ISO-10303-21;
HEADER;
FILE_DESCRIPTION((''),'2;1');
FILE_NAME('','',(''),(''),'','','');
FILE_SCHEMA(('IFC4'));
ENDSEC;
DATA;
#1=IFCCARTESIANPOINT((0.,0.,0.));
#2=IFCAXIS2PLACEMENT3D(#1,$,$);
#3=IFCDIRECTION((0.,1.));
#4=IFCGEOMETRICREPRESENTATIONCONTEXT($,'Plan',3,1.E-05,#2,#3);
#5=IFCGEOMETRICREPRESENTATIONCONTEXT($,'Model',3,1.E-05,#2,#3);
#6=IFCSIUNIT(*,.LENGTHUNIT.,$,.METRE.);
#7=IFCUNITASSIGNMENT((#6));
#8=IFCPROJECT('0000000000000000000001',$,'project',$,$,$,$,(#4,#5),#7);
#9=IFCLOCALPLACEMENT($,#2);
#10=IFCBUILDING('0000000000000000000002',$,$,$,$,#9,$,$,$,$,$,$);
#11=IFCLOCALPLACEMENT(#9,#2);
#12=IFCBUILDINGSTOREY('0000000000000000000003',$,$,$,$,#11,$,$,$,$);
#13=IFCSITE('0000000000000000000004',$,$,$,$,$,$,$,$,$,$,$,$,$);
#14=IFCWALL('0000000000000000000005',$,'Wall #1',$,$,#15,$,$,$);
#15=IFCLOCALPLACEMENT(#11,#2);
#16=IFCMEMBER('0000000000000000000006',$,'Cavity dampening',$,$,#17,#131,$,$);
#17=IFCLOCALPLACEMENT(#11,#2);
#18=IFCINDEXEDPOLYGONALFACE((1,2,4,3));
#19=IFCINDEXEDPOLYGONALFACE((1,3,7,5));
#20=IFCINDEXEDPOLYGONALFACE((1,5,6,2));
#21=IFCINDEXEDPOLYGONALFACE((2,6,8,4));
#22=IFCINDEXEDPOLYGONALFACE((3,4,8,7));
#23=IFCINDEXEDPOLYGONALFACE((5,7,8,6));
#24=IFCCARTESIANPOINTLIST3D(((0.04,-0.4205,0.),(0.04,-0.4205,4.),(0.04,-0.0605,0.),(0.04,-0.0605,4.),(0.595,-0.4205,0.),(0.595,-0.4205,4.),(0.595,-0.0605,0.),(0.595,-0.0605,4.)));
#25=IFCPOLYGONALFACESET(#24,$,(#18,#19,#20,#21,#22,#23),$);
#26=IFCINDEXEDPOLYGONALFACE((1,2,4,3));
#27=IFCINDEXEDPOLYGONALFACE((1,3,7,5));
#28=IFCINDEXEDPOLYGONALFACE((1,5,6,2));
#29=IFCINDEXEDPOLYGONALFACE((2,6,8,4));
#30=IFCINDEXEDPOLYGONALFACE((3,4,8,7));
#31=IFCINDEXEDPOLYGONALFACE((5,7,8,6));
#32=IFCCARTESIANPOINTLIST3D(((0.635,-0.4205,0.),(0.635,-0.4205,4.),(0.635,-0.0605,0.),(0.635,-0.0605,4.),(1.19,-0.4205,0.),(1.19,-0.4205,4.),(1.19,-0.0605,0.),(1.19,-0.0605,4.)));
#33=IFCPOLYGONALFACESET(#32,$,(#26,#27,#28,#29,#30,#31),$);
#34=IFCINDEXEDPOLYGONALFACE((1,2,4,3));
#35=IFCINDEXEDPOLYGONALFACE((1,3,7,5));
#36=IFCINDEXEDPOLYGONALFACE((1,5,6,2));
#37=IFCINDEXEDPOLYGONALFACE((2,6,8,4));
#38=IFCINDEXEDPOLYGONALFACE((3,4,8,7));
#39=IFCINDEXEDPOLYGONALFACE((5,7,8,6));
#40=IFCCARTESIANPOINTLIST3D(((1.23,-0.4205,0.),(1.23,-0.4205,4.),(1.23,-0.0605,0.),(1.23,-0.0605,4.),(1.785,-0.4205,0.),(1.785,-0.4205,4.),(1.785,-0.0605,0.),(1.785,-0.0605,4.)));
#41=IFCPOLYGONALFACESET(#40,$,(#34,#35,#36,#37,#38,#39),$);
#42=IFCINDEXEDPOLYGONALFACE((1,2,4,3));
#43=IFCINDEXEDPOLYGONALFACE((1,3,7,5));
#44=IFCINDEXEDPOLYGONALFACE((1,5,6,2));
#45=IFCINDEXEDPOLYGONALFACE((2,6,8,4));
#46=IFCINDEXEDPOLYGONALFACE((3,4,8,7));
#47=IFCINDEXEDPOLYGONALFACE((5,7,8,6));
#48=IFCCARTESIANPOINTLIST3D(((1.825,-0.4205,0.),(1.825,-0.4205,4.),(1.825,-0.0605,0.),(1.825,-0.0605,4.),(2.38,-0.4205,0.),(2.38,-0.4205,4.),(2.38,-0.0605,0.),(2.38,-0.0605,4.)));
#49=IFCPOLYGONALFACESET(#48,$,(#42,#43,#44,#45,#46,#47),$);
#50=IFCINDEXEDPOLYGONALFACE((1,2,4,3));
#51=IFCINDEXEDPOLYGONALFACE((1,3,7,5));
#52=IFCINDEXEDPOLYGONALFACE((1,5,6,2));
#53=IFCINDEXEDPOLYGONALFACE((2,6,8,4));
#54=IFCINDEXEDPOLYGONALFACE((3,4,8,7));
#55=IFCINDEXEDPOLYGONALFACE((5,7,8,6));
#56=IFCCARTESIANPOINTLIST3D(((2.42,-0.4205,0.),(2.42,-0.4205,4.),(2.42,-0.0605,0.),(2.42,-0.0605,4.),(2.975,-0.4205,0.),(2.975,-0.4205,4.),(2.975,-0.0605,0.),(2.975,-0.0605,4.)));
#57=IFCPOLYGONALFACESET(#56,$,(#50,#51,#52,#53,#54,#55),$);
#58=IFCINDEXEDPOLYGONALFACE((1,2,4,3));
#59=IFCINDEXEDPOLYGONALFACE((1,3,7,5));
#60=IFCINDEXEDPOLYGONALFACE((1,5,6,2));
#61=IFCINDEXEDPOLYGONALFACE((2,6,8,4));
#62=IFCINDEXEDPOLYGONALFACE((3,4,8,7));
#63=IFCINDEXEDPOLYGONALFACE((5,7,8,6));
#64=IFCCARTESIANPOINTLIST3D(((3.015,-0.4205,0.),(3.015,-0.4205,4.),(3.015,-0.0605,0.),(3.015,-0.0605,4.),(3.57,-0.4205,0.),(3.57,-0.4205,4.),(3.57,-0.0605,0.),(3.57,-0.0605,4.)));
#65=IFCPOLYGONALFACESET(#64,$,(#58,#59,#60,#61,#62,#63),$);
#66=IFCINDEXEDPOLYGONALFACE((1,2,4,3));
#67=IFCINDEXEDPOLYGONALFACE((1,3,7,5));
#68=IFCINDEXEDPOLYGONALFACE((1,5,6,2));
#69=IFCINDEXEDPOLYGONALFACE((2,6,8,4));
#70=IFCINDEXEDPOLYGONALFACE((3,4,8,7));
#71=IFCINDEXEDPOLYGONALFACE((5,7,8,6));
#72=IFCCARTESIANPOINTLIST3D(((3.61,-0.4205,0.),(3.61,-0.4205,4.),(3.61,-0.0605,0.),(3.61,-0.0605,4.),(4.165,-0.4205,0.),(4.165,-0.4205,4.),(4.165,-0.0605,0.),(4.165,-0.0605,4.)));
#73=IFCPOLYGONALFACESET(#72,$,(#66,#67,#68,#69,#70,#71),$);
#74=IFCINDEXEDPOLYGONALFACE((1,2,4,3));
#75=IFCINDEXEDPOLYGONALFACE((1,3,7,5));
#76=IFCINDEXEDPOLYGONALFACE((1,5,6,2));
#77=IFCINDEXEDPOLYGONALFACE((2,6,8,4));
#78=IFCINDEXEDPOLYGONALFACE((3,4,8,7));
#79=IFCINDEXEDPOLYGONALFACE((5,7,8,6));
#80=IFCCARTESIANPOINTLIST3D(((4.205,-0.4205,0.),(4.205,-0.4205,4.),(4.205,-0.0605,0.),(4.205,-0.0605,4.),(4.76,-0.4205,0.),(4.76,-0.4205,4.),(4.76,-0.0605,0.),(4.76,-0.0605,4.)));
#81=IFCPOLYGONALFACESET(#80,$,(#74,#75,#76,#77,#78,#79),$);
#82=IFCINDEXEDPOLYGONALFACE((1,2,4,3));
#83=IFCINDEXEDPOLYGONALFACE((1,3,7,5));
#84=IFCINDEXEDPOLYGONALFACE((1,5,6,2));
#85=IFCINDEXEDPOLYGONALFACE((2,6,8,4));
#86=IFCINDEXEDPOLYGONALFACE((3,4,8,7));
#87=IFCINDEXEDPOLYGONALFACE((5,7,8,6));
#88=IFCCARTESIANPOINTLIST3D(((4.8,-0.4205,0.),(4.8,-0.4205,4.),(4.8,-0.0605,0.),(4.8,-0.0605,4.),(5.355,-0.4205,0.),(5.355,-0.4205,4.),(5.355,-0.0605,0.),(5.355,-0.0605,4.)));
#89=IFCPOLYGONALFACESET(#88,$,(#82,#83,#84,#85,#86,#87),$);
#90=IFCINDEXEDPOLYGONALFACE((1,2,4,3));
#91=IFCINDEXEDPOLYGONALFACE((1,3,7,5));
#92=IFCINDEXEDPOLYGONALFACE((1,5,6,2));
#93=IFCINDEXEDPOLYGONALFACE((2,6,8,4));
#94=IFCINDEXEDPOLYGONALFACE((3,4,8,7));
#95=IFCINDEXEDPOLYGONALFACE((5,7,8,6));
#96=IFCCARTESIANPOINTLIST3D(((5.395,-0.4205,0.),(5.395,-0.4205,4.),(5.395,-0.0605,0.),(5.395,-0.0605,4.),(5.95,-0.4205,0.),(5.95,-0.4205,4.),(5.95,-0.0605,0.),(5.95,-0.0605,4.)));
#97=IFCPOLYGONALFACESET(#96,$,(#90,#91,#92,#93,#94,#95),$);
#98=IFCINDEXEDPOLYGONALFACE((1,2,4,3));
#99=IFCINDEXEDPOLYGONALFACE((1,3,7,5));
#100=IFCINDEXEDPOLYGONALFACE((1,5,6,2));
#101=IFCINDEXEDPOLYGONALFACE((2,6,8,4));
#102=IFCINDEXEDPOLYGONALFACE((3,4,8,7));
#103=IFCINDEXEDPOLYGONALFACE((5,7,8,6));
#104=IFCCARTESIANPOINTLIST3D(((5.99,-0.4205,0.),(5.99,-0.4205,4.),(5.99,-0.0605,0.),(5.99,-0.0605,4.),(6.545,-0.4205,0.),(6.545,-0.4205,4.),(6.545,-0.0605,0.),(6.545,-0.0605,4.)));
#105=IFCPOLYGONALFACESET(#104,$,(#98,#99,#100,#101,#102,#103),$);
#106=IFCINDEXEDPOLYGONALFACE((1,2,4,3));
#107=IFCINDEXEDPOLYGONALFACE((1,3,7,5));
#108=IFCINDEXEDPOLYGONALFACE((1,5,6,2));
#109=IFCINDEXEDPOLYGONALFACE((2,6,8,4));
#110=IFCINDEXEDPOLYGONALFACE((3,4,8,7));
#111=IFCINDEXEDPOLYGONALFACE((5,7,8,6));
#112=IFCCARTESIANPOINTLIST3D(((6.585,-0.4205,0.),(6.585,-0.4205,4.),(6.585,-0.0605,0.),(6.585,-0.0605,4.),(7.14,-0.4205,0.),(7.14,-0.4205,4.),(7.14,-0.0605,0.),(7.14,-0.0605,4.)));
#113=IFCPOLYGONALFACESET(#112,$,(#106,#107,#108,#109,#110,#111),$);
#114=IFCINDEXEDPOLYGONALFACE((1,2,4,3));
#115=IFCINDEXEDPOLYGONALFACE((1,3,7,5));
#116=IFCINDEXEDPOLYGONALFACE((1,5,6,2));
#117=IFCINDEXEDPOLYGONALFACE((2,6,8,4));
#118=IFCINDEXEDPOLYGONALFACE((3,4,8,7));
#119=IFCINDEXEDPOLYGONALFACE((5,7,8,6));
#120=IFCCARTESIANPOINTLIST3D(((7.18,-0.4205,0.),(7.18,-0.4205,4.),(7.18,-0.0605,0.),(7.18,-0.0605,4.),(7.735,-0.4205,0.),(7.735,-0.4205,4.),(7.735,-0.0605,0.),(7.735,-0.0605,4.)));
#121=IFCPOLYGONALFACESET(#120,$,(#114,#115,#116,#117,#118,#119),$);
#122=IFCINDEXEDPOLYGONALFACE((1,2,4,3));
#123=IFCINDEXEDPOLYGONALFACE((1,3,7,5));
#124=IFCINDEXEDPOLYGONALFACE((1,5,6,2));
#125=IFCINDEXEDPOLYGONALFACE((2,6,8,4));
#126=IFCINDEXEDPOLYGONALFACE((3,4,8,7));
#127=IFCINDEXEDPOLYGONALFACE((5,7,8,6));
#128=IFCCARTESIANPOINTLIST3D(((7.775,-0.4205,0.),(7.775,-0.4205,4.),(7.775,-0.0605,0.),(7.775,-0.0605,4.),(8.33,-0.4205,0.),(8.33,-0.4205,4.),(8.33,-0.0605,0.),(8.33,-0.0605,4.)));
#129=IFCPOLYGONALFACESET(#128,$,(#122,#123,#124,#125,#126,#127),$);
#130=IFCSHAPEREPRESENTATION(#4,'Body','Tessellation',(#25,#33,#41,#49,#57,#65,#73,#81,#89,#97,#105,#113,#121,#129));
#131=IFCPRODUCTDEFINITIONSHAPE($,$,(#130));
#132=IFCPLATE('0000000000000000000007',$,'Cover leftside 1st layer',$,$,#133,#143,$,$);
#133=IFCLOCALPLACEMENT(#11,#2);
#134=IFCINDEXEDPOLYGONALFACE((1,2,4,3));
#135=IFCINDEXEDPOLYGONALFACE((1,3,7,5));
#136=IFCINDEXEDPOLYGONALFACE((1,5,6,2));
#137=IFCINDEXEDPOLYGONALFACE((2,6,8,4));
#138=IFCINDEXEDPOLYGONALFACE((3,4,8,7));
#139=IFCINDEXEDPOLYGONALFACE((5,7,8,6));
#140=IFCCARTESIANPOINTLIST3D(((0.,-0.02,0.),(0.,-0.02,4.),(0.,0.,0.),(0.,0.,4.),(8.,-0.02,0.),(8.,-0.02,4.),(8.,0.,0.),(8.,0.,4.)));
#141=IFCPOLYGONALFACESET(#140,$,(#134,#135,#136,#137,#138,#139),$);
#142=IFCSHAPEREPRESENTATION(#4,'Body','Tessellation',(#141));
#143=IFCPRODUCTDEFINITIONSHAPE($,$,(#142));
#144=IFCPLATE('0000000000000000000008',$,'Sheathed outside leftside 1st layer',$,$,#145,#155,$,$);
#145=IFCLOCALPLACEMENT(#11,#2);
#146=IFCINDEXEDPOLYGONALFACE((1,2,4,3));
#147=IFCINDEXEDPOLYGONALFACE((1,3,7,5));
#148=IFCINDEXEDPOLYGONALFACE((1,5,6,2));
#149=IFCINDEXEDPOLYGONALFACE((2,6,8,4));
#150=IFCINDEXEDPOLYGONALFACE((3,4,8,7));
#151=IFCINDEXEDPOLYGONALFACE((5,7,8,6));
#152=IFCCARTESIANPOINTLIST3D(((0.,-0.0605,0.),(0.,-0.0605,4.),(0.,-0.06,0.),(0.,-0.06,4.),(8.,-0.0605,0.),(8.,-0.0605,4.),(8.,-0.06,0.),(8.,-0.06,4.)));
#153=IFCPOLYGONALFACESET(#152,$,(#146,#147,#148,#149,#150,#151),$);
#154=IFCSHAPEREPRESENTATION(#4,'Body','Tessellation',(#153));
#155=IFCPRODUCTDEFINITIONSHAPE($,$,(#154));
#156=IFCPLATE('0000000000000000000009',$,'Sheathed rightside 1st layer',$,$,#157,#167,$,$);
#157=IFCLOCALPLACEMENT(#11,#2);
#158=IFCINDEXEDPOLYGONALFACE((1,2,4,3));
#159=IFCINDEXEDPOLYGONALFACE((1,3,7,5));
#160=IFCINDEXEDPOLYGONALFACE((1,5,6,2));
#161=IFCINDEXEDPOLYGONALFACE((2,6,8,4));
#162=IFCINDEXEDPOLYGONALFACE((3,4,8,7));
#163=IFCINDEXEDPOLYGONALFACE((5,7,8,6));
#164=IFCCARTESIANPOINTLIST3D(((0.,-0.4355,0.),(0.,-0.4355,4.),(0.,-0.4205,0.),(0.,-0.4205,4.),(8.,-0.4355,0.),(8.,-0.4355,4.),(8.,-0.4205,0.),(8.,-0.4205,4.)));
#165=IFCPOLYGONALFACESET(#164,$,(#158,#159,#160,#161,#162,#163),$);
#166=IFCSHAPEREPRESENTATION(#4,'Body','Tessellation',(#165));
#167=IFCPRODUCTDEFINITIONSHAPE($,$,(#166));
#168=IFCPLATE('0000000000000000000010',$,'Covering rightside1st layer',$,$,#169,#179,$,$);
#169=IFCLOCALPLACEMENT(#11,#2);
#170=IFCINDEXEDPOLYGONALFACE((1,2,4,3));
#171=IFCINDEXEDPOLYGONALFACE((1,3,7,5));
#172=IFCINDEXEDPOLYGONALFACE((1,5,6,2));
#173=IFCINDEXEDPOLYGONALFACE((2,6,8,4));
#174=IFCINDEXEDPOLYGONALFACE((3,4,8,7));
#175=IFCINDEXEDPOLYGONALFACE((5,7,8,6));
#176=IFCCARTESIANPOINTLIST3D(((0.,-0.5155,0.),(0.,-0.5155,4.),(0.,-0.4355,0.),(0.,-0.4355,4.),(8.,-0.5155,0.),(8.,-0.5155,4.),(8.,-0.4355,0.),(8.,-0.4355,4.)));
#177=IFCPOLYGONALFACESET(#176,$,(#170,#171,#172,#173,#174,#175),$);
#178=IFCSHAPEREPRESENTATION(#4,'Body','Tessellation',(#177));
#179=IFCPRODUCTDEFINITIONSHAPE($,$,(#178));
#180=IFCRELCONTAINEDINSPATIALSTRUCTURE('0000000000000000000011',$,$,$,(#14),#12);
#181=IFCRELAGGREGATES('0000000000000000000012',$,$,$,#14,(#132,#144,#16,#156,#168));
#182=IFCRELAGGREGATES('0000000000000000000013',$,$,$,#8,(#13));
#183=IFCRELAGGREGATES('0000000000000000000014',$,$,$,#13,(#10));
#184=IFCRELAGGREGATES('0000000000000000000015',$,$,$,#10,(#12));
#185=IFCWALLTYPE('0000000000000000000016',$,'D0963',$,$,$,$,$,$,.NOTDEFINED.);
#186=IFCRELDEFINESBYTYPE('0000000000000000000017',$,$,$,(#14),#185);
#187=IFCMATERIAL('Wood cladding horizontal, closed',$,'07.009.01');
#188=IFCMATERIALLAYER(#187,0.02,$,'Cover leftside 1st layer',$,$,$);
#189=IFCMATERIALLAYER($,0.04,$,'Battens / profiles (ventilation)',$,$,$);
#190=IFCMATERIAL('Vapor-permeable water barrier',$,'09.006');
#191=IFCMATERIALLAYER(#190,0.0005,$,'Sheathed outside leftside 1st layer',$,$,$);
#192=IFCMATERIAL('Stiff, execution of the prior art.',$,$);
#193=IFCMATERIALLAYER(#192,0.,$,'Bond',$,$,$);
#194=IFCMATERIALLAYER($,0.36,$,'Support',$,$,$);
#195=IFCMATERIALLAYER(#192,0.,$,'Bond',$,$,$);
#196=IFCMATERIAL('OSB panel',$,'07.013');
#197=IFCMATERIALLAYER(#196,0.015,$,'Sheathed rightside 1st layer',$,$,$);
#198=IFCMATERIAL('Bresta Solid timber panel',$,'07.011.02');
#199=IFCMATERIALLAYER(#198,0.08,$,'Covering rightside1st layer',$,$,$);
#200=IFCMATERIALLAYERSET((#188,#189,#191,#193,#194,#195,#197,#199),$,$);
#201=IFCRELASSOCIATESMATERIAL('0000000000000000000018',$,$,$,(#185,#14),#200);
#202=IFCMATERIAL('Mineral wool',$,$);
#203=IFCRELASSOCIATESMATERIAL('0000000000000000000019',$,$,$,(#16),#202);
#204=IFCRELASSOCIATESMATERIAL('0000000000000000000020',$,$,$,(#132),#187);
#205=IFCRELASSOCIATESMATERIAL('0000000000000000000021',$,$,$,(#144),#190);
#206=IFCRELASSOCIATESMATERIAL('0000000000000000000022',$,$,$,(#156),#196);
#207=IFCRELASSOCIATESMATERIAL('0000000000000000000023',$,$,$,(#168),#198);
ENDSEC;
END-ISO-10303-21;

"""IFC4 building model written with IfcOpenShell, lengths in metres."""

from ifc_helpers import new_model, si_unit, direction, frame, frame_2d, origin, origin_with_axes, place, context, project, spatial, rectangle, extrude, material, layer, layer_set, type_object, element, aggregate, save


model = new_model("IFC4")

# Units and contexts
plan_context = context("Plan", 3, precision=1e-05, world=origin(), true_north=direction((0.0, 1.0)))
model_context = context("Model", 3, precision=1e-05, world=origin(), true_north=direction((0.0, 1.0)))
ifc_project = project(units=[si_unit("LENGTHUNIT", "METRE")], contexts=[plan_context, model_context])

# Site, building, storey
site = spatial("IfcSite", under=ifc_project)
building_placement = place(None, origin())
building = spatial("IfcBuilding", under=site, at=building_placement)
storey_placement = place(building_placement, origin())
storey = spatial("IfcBuildingStorey", under=building, at=storey_placement)

# Wall, member, plates
ifc_material_1 = material(Name="Wood cladding horizontal, closed", Category="07.009.01")
ifc_layer_1 = layer(ifc_material_1, 0.02, Name="Cover leftside 1st layer")
ifc_layer_2 = layer(None, 0.04, Name="Battens / profiles (ventilation)")
ifc_material_2 = material(Name="Vapor-permeable water barrier", Category="09.006")
ifc_layer_3 = layer(ifc_material_2, 0.0005, Name="Sheathed outside leftside 1st layer")
ifc_material_3 = material(Name="Stiff, execution of the prior art.")
ifc_layer_4 = layer(ifc_material_3, 0.0, Name="Bond")
ifc_layer_5 = layer(None, 0.36, Name="Support")
ifc_layer_6 = layer(ifc_material_3, 0.0, Name="Bond")
ifc_material_4 = material(Name="OSB panel", Category="07.013")
ifc_layer_7 = layer(ifc_material_4, 0.015, Name="Sheathed rightside 1st layer")
ifc_material_5 = material(Name="Bresta Solid timber panel", Category="07.011.02")
ifc_layer_8 = layer(ifc_material_5, 0.08, Name="Covering rightside1st layer")
ifc_layer_set = layer_set([ifc_layer_1, ifc_layer_2, ifc_layer_3, ifc_layer_4, ifc_layer_5, ifc_layer_6, ifc_layer_7, ifc_layer_8])
wall_type = type_object("IfcWallType", Name="D0963", PredefinedType="NOTDEFINED", material=ifc_layer_set)
wall_placement = place(None, frame((0.0, 0.0, 0.0), z_axis=(0.0, -1.0, 0.0), x_axis=(1.0, 0.0, 0.0)))
wall = element("IfcWall", 1, at=wall_placement, inside=storey, type_object=wall_type, material=ifc_layer_set, Name="Wall #1")
ifc_material_6 = material(Name="Mineral wool")
member_1_placement = place(wall_placement, origin())
member_1 = element("IfcMember", 2, at=member_1_placement, material=ifc_material_6, Name="Cavity dampening", context=plan_context, shape_type="SweptSolid", body=[
    extrude(rectangle(XDim=0.555, YDim=0.36, at=frame_2d((0.2775, 0.18), x_axis=(1.0, 0.0))), frame((0.04, 4.0, 0.0605), z_axis=(0.0, -1.0, 0.0), x_axis=(1.0, 0.0, 0.0)), (0.0, 0.0, 1.0), 4.0),
    extrude(rectangle(XDim=0.555, YDim=0.36, at=frame_2d((0.2775, 0.18), x_axis=(1.0, 0.0))), frame((0.635, 4.0, 0.0605), z_axis=(0.0, -1.0, 0.0), x_axis=(1.0, 0.0, 0.0)), (0.0, 0.0, 1.0), 4.0),
    extrude(rectangle(XDim=0.555, YDim=0.36, at=frame_2d((0.2775, 0.18), x_axis=(1.0, 0.0))), frame((1.23, 4.0, 0.0605), z_axis=(0.0, -1.0, 0.0), x_axis=(1.0, 0.0, 0.0)), (0.0, 0.0, 1.0), 4.0),
    extrude(rectangle(XDim=0.555, YDim=0.36, at=frame_2d((0.2775, 0.18), x_axis=(1.0, 0.0))), frame((1.825, 4.0, 0.0605), z_axis=(0.0, -1.0, 0.0), x_axis=(1.0, 0.0, 0.0)), (0.0, 0.0, 1.0), 4.0),
    extrude(rectangle(XDim=0.555, YDim=0.36, at=frame_2d((0.2775, 0.18), x_axis=(1.0, 0.0))), frame((2.42, 4.0, 0.0605), z_axis=(0.0, -1.0, 0.0), x_axis=(1.0, 0.0, 0.0)), (0.0, 0.0, 1.0), 4.0),
    extrude(rectangle(XDim=0.555, YDim=0.36, at=frame_2d((0.2775, 0.18), x_axis=(1.0, 0.0))), frame((3.015, 4.0, 0.0605), z_axis=(0.0, -1.0, 0.0), x_axis=(1.0, 0.0, 0.0)), (0.0, 0.0, 1.0), 4.0),
    extrude(rectangle(XDim=0.555, YDim=0.36, at=frame_2d((0.2775, 0.18), x_axis=(1.0, 0.0))), frame((3.61, 4.0, 0.0605), z_axis=(0.0, -1.0, 0.0), x_axis=(1.0, 0.0, 0.0)), (0.0, 0.0, 1.0), 4.0),
    extrude(rectangle(XDim=0.555, YDim=0.36, at=frame_2d((0.2775, 0.18), x_axis=(1.0, 0.0))), frame((4.205, 4.0, 0.0605), z_axis=(0.0, -1.0, 0.0), x_axis=(1.0, 0.0, 0.0)), (0.0, 0.0, 1.0), 4.0),
    extrude(rectangle(XDim=0.555, YDim=0.36, at=frame_2d((0.2775, 0.18), x_axis=(1.0, 0.0))), frame((4.8, 4.0, 0.0605), z_axis=(0.0, -1.0, 0.0), x_axis=(1.0, 0.0, 0.0)), (0.0, 0.0, 1.0), 4.0),
    extrude(rectangle(XDim=0.555, YDim=0.36, at=frame_2d((0.2775, 0.18), x_axis=(1.0, 0.0))), frame((5.395, 4.0, 0.0605), z_axis=(0.0, -1.0, 0.0), x_axis=(1.0, 0.0, 0.0)), (0.0, 0.0, 1.0), 4.0),
    extrude(rectangle(XDim=0.555, YDim=0.36, at=frame_2d((0.2775, 0.18), x_axis=(1.0, 0.0))), frame((5.99, 4.0, 0.0605), z_axis=(0.0, -1.0, 0.0), x_axis=(1.0, 0.0, 0.0)), (0.0, 0.0, 1.0), 4.0),
    extrude(rectangle(XDim=0.555, YDim=0.36, at=frame_2d((0.2775, 0.18), x_axis=(1.0, 0.0))), frame((6.585, 4.0, 0.0605), z_axis=(0.0, -1.0, 0.0), x_axis=(1.0, 0.0, 0.0)), (0.0, 0.0, 1.0), 4.0),
    extrude(rectangle(XDim=0.555, YDim=0.36, at=frame_2d((0.2775, 0.18), x_axis=(1.0, 0.0))), frame((7.18, 4.0, 0.0605), z_axis=(0.0, -1.0, 0.0), x_axis=(1.0, 0.0, 0.0)), (0.0, 0.0, 1.0), 4.0),
    extrude(rectangle(XDim=0.555, YDim=0.36, at=frame_2d((0.2775, 0.18), x_axis=(1.0, 0.0))), frame((7.775, 4.0, 0.0605), z_axis=(0.0, -1.0, 0.0), x_axis=(1.0, 0.0, 0.0)), (0.0, 0.0, 1.0), 4.0),
])
plate_1_placement = place(wall_placement, origin())
plate_1 = element("IfcPlate", 3, at=plate_1_placement, material=ifc_material_1, Name="Cover leftside 1st layer", context=plan_context, shape_type="SweptSolid", body=[
    extrude(rectangle(XDim=8.0, YDim=4.0, at=frame_2d((4.0, 2.0), x_axis=(1.0, 0.0))), origin_with_axes(), (0.0, 0.0, 1.0), 0.02),
])
plate_2_placement = place(wall_placement, origin())
plate_2 = element("IfcPlate", 4, at=plate_2_placement, material=ifc_material_2, Name="Sheathed outside leftside 1st layer", context=plan_context, shape_type="SweptSolid", body=[
    extrude(rectangle(XDim=8.0, YDim=4.0, at=frame_2d((4.0, 2.0), x_axis=(1.0, 0.0))), frame((0.0, 0.0, 0.06), z_axis=(0.0, 0.0, 1.0), x_axis=(1.0, 0.0, 0.0)), (0.0, 0.0, 1.0), 0.0005),
])
plate_3_placement = place(wall_placement, origin())
plate_3 = element("IfcPlate", 5, at=plate_3_placement, material=ifc_material_4, Name="Sheathed rightside 1st layer", context=plan_context, shape_type="SweptSolid", body=[
    extrude(rectangle(XDim=8.0, YDim=4.0, at=frame_2d((4.0, 2.0), x_axis=(1.0, 0.0))), frame((0.0, 0.0, 0.4205), z_axis=(0.0, 0.0, 1.0), x_axis=(1.0, 0.0, 0.0)), (0.0, 0.0, 1.0), 0.015),
])
plate_4_placement = place(wall_placement, origin())
plate_4 = element("IfcPlate", 6, at=plate_4_placement, material=ifc_material_5, Name="Covering rightside1st layer", context=plan_context, shape_type="SweptSolid", body=[
    extrude(rectangle(XDim=8.0, YDim=4.0, at=frame_2d((4.0, 2.0), x_axis=(1.0, 0.0))), frame((0.0, 0.0, 0.4355), z_axis=(0.0, 0.0, 1.0), x_axis=(1.0, 0.0, 0.0)), (0.0, 0.0, 1.0), 0.08),
])
aggregate(wall, [plate_1, plate_2, member_1, plate_3, plate_4])

save(model, "model.ifc")
